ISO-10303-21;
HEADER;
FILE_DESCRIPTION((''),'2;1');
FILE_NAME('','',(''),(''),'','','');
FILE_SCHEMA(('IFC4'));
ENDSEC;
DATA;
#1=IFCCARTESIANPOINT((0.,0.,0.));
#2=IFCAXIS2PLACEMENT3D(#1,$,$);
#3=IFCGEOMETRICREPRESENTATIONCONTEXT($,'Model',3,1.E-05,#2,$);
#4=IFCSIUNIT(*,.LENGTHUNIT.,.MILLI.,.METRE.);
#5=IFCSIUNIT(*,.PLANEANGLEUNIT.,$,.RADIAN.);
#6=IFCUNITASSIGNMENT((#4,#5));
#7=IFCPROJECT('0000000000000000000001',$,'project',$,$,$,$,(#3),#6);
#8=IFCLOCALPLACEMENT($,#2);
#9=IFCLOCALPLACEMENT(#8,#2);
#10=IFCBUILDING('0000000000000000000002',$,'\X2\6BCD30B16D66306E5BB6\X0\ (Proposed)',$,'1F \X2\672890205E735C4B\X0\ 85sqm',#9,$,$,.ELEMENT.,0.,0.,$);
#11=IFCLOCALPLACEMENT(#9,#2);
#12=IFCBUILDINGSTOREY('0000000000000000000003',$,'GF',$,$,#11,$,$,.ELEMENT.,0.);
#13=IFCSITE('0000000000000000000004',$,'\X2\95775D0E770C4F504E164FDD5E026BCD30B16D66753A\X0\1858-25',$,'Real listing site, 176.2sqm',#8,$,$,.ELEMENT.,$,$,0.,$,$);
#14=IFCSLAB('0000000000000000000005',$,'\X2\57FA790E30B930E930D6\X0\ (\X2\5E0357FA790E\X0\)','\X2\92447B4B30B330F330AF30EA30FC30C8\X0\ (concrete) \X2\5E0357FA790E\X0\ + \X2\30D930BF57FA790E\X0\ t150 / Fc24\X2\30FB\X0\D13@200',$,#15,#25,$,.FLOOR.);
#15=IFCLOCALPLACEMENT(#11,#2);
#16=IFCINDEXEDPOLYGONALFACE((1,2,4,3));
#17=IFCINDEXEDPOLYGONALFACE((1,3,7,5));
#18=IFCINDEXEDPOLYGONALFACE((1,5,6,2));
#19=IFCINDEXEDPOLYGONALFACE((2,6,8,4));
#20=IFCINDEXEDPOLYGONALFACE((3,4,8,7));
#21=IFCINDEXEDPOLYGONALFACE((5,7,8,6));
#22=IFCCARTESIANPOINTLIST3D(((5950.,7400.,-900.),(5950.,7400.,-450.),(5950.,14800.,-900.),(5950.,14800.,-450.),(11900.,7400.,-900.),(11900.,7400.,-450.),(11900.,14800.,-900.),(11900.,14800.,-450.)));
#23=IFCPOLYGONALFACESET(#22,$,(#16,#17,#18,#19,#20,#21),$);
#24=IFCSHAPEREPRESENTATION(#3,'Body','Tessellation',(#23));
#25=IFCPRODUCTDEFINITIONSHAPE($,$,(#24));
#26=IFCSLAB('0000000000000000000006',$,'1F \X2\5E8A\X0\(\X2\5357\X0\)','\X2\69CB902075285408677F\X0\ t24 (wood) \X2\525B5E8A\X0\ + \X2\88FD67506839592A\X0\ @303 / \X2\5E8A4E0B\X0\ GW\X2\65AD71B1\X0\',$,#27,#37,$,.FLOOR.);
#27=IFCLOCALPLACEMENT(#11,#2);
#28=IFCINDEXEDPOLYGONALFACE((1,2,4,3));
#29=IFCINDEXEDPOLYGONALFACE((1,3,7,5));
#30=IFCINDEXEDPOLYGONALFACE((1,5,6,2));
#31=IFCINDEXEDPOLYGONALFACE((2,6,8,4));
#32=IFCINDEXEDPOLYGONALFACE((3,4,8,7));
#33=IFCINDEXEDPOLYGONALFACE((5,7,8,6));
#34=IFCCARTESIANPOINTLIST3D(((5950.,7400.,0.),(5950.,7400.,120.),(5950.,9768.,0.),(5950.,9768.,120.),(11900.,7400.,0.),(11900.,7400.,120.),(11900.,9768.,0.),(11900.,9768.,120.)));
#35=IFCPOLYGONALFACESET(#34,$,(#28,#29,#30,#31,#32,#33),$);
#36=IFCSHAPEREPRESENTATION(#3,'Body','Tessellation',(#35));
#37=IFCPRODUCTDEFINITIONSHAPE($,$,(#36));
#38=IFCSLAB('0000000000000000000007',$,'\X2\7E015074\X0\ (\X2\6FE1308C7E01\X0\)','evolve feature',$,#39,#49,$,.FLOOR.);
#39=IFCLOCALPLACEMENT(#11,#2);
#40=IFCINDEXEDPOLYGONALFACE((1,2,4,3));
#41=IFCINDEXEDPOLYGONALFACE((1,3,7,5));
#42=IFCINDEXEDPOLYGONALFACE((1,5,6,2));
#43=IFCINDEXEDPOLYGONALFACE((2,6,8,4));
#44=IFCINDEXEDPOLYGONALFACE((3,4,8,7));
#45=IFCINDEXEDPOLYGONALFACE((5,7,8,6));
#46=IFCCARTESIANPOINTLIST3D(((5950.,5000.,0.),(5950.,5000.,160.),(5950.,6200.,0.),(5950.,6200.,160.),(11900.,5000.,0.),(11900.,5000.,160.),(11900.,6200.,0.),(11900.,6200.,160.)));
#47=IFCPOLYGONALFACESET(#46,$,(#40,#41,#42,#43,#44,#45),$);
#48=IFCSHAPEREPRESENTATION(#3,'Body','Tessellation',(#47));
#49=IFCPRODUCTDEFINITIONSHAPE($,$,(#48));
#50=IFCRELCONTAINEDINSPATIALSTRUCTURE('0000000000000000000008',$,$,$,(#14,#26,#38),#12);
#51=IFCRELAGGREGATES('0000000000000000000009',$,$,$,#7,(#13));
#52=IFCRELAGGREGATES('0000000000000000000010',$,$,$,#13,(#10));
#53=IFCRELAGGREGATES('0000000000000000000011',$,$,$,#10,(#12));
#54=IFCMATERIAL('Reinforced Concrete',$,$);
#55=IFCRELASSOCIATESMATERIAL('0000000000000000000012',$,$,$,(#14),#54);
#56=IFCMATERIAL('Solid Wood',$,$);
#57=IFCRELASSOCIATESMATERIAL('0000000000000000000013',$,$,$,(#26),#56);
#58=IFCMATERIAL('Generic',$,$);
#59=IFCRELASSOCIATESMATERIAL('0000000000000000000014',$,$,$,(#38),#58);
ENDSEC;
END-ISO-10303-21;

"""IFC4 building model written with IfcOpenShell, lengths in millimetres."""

from ifc_helpers import new_model, si_unit, frame, frame_2d, origin, place, context, project, spatial, rectangle, extrude, material, element, save


model = new_model("IFC4")

# Units and contexts
model_context = context("Model", 3, precision=1e-05, world=origin())
ifc_project = project(units=[si_unit("LENGTHUNIT", "METRE", prefix="MILLI"), si_unit("PLANEANGLEUNIT", "RADIAN")], contexts=[model_context])

# Site, building, storey
site_placement = place(None, origin())
site = spatial("IfcSite", under=ifc_project, at=site_placement, Name="長崎県佐世保市母ケ浦町1858-25", ObjectType="Real listing site, 176.2sqm", CompositionType="ELEMENT", RefElevation=0.0)
building_placement = place(site_placement, origin())
building = spatial("IfcBuilding", under=site, at=building_placement, Name="母ケ浦の家 (Proposed)", ObjectType="1F 木造平屋 85sqm", CompositionType="ELEMENT", ElevationOfRefHeight=0.0, ElevationOfTerrain=0.0)
storey_placement = place(building_placement, origin())
storey = spatial("IfcBuildingStorey", under=building, at=storey_placement, Name="GF", CompositionType="ELEMENT", Elevation=0.0)

# Slabs
ifc_material_1 = material(Name="Reinforced Concrete")
slab_1_placement = place(storey_placement, frame((2975.0, 3700.0, -450.0)))
element("IfcSlab", 1, at=slab_1_placement, inside=storey, material=ifc_material_1, Name="基礎スラブ (布基礎)", Description="鉄筋コンクリート (concrete) 布基礎 + ベタ基礎 t150 / Fc24・D13@200", PredefinedType="FLOOR", context=model_context, shape_type="SweptSolid", body=[
    extrude(rectangle(XDim=5950.0, YDim=7400.0, at=frame_2d((2975.0, 3700.0))), frame((2975.0, 3700.0, -450.0)), (0.0, 0.0, 1.0), 450.0),
])
ifc_material_2 = material(Name="Solid Wood")
slab_2_placement = place(storey_placement, frame((2975.0, 3700.0, 0.0)))
element("IfcSlab", 2, at=slab_2_placement, inside=storey, material=ifc_material_2, Name="1F 床(南)", Description="構造用合板 t24 (wood) 剛床 + 製材根太 @303 / 床下 GW断熱", PredefinedType="FLOOR", context=model_context, shape_type="SweptSolid", body=[
    extrude(rectangle(XDim=5950.0, YDim=2368.0, at=frame_2d((2975.0, 1184.0))), frame((2975.0, 3700.0, 0.0)), (0.0, 0.0, 1.0), 120.0),
])
ifc_material_3 = material(Name="Generic")
slab_3_placement = place(storey_placement, frame((2975.0, 2500.0, 0.0)))
element("IfcSlab", 3, at=slab_3_placement, inside=storey, material=ifc_material_3, Name="縁側 (濡れ縁)", Description="evolve feature", PredefinedType="FLOOR", context=model_context, shape_type="SweptSolid", body=[
    extrude(rectangle(XDim=5950.0, YDim=1200.0, at=frame_2d((2975.0, 600.0))), frame((2975.0, 2500.0, 0.0)), (0.0, 0.0, 1.0), 160.0),
])

save(model, "model.ifc")
